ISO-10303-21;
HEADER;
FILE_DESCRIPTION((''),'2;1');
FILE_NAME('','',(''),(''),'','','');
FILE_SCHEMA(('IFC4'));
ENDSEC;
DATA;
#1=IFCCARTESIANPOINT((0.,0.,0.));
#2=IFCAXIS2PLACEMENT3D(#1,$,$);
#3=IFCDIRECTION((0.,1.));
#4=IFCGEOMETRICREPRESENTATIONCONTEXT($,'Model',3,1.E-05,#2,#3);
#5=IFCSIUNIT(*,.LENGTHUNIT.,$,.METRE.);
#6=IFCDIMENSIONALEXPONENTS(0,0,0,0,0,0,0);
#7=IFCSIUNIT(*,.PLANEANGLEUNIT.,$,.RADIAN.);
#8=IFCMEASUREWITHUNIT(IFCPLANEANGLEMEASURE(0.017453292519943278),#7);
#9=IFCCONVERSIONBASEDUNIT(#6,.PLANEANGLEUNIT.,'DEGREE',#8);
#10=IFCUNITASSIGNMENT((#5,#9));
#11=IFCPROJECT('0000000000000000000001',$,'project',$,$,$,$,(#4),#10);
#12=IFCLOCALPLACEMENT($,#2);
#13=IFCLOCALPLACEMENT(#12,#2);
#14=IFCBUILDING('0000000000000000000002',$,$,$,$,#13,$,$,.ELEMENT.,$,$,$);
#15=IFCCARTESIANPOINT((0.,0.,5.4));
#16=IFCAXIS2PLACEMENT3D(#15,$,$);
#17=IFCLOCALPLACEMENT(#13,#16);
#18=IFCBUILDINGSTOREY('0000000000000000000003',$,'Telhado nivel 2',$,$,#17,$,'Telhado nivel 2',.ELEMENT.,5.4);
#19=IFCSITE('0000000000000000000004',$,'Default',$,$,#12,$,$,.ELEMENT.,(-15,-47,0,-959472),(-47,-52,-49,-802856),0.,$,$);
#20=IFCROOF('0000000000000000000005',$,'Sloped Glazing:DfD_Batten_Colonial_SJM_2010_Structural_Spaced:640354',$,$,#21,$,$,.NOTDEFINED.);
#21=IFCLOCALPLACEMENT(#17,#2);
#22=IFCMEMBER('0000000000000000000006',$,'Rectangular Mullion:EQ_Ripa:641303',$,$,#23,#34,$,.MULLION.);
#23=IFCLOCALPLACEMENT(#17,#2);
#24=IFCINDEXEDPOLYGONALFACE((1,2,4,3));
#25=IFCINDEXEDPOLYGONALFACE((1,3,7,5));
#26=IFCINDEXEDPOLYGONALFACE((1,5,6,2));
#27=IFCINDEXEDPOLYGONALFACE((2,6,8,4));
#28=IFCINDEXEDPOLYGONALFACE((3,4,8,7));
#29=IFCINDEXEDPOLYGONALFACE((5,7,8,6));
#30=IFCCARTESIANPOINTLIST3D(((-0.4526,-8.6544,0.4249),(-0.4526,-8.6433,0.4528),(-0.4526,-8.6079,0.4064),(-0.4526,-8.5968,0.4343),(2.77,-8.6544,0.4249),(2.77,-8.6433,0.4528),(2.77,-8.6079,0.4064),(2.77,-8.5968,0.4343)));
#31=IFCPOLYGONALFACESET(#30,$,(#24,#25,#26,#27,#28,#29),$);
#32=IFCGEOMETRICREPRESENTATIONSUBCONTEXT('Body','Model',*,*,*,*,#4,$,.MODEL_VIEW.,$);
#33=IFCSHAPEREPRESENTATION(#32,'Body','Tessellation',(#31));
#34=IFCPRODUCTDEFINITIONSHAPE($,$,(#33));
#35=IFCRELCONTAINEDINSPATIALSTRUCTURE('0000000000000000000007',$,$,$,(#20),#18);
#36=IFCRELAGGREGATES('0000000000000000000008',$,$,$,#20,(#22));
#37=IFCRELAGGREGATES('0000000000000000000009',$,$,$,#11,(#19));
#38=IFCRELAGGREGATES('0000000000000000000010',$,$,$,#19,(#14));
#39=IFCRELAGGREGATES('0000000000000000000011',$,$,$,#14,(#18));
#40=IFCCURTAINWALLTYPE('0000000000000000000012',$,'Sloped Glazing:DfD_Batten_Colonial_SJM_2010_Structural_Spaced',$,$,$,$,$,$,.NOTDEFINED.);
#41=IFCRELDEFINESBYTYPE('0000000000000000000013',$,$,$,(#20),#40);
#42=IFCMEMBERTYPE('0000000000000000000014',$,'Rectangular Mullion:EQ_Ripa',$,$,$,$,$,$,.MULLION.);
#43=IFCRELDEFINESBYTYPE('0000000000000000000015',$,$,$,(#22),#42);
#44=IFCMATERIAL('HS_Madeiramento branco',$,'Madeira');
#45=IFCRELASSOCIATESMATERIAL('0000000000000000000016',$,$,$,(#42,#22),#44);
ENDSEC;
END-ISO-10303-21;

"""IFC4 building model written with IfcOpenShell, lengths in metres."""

from ifc_helpers import new_model, entity, si_unit, converted_unit, direction, frame, origin, place, context, subcontext, project, spatial, indexed_curve, outline, extrude, source, transform, mapped, material, type_object, type_shapes, element, aggregate, save


model = new_model("IFC4")

# Units and contexts
model_context = context("Model", 3, precision=1e-05, world=origin(), true_north=direction((0.0, 1.0)))
body_context = subcontext(model_context, "Body", "Model", "MODEL_VIEW")
ifc_project = project(units=[si_unit("LENGTHUNIT", "METRE"), converted_unit("PLANEANGLEUNIT", "DEGREE", entity("IfcPlaneAngleMeasure", 0.017453292519943278), si_unit("PLANEANGLEUNIT", "RADIAN"), dimensions=[0, 0, 0, 0, 0, 0, 0])], contexts=[model_context])

# Site, building, storey
site_placement = place(None, origin())
site = spatial("IfcSite", under=ifc_project, at=site_placement, Name="Default", CompositionType="ELEMENT", RefLatitude=(-15, -47, 0, -959472), RefLongitude=(-47, -52, -49, -802856), RefElevation=0.0)
building_placement = place(site_placement, origin())
building = spatial("IfcBuilding", under=site, at=building_placement, CompositionType="ELEMENT")
storey_placement = place(building_placement, frame((0.0, 0.0, 5.4)))
storey = spatial("IfcBuildingStorey", under=building, at=storey_placement, Name="Telhado nivel 2", LongName="Telhado nivel 2", CompositionType="ELEMENT", Elevation=5.4)

# Roof, member
curtain_wall_type = type_object("IfcCurtainWallType", Name="Sloped Glazing:DfD_Batten_Colonial_SJM_2010_Structural_Spaced", PredefinedType="NOTDEFINED")
roof_placement = place(storey_placement, frame((0.0, 0.0, -5.4)))
roof = element("IfcRoof", 1, at=roof_placement, inside=storey, type_object=curtain_wall_type, Name="Sloped Glazing:DfD_Batten_Colonial_SJM_2010_Structural_Spaced:640354", PredefinedType="NOTDEFINED")
ifc_material = material(Name="HS_Madeiramento branco", Category="Madeira")
member_type_1 = type_object("IfcMemberType", Name="Rectangular Mullion:EQ_Ripa", PredefinedType="MULLION", material=ifc_material)
shared_shape_1 = source(origin(), body_context, "Body", "SweptSolid", [
    extrude(outline(indexed_curve([(-0.025, -0.015), (0.025, -0.015), (0.025, 0.015), (-0.025, 0.015), (-0.025, -0.015)], self_intersect=False)), frame((0.0, 0.0, -3.2226), z_axis=(0.0, 0.0, 1.0), x_axis=(-1.0, 0.0, 0.0)), (0.0, 0.0, 1.0), 3.2226),
])
type_shapes(member_type_1, [shared_shape_1])
member_1_placement = place(roof_placement, frame((2.77, -8.6256, 5.8296), z_axis=(1.0, 0.0, 0.0), x_axis=(0.0, -0.928878, 0.370385)))
member_1 = element("IfcMember", 2, at=member_1_placement, type_object=member_type_1, material=ifc_material, Name="Rectangular Mullion:EQ_Ripa:641303", PredefinedType="MULLION", context=body_context, shape_type="MappedRepresentation", body=[
    mapped(shared_shape_1, transform((0.0, 0.0, 0.0), scale=1.0)),
])
aggregate(roof, [member_1])

save(model, "model.ifc")
